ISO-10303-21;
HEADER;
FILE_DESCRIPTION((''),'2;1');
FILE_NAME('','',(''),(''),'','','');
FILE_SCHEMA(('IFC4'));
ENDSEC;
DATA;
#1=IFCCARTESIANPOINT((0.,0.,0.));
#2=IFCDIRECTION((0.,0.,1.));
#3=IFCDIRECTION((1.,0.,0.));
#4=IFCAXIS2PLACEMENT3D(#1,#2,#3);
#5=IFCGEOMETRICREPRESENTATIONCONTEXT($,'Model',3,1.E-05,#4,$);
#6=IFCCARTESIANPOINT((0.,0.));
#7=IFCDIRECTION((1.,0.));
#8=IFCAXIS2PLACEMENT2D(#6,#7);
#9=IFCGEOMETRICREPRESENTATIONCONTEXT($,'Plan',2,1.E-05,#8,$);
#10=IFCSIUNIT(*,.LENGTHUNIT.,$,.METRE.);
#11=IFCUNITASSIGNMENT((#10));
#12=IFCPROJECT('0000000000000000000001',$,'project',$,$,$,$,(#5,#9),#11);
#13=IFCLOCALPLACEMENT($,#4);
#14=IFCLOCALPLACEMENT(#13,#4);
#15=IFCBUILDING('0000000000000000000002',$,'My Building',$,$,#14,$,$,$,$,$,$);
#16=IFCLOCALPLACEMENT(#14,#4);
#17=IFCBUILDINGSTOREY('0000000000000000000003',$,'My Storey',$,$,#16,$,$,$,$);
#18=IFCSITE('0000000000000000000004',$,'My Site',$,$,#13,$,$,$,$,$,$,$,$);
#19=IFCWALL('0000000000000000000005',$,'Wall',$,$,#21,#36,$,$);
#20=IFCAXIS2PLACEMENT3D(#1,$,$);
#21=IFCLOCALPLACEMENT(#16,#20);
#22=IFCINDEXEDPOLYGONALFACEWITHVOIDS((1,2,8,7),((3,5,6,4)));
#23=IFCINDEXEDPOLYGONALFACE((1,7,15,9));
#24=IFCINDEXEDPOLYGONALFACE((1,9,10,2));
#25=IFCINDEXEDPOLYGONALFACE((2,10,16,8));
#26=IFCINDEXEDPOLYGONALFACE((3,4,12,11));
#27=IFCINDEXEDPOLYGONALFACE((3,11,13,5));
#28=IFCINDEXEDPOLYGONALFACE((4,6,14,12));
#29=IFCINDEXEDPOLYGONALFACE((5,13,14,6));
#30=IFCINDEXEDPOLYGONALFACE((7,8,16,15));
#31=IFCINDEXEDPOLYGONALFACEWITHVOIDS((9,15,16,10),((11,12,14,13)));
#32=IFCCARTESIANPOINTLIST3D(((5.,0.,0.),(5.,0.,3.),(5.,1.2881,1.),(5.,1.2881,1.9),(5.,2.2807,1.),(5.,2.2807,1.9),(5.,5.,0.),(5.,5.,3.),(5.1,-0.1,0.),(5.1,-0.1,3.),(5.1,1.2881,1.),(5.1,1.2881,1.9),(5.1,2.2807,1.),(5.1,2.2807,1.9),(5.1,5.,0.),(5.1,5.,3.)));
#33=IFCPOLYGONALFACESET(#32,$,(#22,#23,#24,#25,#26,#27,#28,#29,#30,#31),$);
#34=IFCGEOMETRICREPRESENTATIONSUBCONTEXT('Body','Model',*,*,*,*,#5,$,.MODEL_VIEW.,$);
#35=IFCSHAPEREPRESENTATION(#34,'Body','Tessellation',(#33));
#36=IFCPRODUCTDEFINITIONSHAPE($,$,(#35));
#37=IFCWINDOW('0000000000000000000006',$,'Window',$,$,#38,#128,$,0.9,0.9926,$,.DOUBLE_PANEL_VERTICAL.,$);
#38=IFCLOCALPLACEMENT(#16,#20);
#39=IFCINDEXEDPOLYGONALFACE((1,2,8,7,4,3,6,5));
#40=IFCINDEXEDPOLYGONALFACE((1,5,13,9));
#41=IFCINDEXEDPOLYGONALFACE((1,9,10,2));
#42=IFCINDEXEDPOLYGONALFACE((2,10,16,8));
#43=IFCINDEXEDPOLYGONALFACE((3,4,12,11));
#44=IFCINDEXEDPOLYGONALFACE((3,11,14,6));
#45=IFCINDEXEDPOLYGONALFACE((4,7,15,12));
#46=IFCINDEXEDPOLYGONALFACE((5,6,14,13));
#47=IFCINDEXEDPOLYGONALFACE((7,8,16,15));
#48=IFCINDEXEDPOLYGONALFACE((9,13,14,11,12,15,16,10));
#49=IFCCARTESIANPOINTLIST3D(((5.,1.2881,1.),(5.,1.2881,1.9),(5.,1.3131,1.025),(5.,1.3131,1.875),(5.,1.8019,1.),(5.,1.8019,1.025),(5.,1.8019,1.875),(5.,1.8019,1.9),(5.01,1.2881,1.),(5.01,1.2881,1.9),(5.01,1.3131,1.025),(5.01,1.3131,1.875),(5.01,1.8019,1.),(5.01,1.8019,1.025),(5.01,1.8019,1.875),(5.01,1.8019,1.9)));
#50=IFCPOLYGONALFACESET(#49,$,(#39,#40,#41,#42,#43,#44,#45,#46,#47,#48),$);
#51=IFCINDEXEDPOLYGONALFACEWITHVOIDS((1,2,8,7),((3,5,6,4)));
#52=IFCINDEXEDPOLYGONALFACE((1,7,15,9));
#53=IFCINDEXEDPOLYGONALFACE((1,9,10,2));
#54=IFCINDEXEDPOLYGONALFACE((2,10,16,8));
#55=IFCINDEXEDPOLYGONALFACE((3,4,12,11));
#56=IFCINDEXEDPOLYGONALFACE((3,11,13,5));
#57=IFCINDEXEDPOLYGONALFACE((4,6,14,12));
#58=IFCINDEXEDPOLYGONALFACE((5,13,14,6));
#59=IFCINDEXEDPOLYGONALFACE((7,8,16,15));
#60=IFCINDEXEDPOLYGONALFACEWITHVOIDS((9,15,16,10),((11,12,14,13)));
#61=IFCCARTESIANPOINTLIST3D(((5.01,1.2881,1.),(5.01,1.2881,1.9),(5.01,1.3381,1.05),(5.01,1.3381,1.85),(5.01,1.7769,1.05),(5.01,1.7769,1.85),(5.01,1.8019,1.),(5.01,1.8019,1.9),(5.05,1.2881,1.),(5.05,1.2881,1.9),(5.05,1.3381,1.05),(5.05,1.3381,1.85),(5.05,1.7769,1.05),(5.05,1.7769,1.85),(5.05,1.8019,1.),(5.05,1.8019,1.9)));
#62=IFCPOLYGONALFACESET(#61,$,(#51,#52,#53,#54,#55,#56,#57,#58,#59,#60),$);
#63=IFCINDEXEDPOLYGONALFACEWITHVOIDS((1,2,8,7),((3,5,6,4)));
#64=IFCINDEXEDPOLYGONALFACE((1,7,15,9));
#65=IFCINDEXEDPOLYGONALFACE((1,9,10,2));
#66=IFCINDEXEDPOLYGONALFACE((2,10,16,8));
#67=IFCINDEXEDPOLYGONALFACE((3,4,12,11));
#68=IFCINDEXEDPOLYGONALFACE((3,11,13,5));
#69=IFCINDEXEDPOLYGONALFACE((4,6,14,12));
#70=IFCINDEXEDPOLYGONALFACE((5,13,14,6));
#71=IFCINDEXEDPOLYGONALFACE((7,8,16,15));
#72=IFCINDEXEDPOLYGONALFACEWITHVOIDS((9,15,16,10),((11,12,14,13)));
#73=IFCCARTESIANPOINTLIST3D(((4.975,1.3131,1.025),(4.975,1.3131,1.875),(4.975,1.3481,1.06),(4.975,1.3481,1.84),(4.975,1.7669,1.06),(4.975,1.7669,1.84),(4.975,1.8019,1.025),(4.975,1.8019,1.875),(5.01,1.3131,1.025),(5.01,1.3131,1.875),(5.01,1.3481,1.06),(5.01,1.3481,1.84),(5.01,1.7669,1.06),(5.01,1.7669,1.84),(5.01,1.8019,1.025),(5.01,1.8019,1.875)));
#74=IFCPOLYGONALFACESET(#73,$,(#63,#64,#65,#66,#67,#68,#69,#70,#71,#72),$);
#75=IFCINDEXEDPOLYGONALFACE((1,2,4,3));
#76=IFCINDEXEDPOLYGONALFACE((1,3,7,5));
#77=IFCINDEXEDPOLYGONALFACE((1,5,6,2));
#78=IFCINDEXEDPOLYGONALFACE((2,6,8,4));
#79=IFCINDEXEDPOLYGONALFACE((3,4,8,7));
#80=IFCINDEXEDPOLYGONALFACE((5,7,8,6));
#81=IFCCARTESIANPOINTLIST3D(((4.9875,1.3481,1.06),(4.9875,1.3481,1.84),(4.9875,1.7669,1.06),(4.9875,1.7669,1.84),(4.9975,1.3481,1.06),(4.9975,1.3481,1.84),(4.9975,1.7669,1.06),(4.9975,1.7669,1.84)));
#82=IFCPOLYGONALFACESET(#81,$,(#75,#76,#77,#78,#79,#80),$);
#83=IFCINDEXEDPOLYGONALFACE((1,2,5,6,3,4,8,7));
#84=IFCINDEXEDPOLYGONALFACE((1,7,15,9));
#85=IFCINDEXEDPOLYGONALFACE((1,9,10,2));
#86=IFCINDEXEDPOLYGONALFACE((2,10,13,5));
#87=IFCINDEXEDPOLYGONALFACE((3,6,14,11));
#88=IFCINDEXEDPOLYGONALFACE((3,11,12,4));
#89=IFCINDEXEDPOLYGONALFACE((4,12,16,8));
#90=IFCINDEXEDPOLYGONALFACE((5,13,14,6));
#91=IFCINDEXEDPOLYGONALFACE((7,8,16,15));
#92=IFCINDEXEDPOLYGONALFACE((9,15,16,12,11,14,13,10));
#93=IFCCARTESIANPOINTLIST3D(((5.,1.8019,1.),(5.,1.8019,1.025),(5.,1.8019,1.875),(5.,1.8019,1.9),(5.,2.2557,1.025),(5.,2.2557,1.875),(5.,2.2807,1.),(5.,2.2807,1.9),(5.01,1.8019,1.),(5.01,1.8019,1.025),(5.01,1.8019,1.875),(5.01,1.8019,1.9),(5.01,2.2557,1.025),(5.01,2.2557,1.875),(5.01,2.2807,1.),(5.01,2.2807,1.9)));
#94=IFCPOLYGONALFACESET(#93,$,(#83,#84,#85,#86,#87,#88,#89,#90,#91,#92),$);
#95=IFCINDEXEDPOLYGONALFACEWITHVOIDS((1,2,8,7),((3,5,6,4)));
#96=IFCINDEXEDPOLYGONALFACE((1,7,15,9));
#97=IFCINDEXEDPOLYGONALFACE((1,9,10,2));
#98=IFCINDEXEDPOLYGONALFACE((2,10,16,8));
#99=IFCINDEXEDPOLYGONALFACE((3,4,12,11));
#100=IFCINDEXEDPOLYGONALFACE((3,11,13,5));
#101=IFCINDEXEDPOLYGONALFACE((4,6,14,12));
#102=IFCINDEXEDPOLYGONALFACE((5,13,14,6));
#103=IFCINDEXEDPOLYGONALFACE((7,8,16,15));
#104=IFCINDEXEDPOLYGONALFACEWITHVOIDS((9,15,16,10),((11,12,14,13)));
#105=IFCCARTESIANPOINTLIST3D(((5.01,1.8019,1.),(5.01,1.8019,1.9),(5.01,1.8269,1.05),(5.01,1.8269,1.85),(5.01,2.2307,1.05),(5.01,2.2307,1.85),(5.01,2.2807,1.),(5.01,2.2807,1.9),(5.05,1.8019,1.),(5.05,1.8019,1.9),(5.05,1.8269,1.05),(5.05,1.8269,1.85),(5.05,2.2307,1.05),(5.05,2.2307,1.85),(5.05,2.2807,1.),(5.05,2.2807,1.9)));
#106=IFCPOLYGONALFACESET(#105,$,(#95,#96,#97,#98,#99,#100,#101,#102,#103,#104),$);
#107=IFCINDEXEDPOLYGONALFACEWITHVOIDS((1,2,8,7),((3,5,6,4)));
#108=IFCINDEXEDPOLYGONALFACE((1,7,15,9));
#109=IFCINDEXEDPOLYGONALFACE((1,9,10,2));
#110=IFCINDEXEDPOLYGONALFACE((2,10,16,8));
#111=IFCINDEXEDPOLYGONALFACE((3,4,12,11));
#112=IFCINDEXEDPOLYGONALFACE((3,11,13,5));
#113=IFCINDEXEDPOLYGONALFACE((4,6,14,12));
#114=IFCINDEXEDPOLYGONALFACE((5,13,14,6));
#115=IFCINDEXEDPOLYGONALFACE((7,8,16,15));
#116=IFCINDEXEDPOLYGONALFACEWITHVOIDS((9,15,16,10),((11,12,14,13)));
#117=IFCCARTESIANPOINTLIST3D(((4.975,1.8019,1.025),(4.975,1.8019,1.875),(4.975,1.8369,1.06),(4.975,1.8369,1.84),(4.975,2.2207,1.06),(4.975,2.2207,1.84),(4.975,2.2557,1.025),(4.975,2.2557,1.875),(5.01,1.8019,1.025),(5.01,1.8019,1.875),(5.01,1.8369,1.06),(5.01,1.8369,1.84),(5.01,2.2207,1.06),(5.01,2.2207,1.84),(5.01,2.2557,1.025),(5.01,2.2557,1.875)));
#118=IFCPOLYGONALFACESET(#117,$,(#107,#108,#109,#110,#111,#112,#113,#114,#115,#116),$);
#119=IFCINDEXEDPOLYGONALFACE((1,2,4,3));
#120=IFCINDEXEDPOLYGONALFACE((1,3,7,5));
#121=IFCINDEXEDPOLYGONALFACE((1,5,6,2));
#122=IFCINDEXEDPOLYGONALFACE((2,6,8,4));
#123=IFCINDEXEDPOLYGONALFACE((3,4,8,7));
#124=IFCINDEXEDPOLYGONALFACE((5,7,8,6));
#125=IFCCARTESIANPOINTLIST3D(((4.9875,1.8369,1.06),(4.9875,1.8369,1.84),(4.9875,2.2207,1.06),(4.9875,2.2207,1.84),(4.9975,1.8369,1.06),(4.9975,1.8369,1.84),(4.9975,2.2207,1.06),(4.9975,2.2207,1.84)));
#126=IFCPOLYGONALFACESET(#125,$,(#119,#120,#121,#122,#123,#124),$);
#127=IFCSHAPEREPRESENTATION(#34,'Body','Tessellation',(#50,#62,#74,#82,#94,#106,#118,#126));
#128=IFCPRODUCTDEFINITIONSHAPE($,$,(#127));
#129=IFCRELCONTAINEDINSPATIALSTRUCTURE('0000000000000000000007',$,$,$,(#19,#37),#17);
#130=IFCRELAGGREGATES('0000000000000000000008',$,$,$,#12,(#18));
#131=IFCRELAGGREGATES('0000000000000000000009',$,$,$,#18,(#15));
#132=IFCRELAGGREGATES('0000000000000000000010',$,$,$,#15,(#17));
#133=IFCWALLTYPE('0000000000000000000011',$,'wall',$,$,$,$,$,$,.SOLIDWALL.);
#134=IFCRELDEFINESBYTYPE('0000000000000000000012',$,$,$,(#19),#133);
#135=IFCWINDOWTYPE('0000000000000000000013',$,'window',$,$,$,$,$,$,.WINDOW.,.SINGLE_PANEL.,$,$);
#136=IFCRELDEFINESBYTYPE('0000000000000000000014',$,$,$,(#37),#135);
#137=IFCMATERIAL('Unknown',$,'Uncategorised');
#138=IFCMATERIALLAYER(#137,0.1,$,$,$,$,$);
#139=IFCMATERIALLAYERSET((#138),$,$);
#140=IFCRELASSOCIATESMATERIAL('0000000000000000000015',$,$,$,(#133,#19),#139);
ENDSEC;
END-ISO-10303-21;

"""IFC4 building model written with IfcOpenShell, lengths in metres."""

from ifc_helpers import new_model, entity, si_unit, frame, origin_with_axes, origin_2d_with_axis, place, context, subcontext, project, spatial, line, indexed_curve, outline, extrude, shape, source, transform, mapped, material, layer, layer_set, layer_usage, type_object, type_shapes, element, fill, save


model = new_model("IFC4")

# Units and contexts
model_context = context("Model", 3, precision=1e-05, world=origin_with_axes())
plan_context = context("Plan", 2, precision=1e-05, world=origin_2d_with_axis())
body_context_1 = subcontext(model_context, "Body", "Model", "MODEL_VIEW")
body_context_2 = subcontext(plan_context, "Body", "Plan", "PLAN_VIEW")
ifc_project = project(units=[si_unit("LENGTHUNIT", "METRE")], contexts=[model_context, plan_context])

# Site, building, storey
site_placement = place(None, origin_with_axes())
site = spatial("IfcSite", under=ifc_project, at=site_placement, Name="My Site")
building_placement = place(site_placement, origin_with_axes())
building = spatial("IfcBuilding", under=site, at=building_placement, Name="My Building")
storey_placement = place(building_placement, origin_with_axes())
storey = spatial("IfcBuildingStorey", under=building, at=storey_placement, Name="My Storey")

# Shared definitions
ifc_material = material(Name="Unknown", Category="Uncategorised")

# Shared definitions
ifc_layer_1 = layer(ifc_material, 0.1)
ifc_layer_set_1 = layer_set([ifc_layer_1])
wall_type = type_object("IfcWallType", Name="wall", PredefinedType="SOLIDWALL", material=ifc_layer_set_1)
shared_shape_1 = source(origin_with_axes(), body_context_1, "Body", "SweptSolid", [
    extrude(outline(indexed_curve([(0.0, 0.0), (0.9926, 0.0), (0.9926, 0.9), (0.0, 0.9)], segments=[line(1, 2, 3, 4, 1)])), frame((0.0, -0.6, 0.0), z_axis=(0.0, -1.0, 0.0), x_axis=(1.0, 0.0, 0.0)), (0.0, 0.0, -1.0), 1.2),
])
window_type_1 = type_object("IfcWindowType", Name="window", PartitioningType="SINGLE_PANEL", PredefinedType="WINDOW")
shared_shape_2 = source(origin_with_axes(), body_context_1, "Body", "SweptSolid", [
    extrude(outline(indexed_curve([(0.5138, 0.0), (0.0, 0.0), (0.0, 0.9), (0.5138, 0.9), (0.5138, 0.875), (0.025, 0.875), (0.025, 0.025), (0.5138, 0.025)], segments=[line(1, 2, 3, 4, 5, 6, 7, 8, 1)])), frame((0.0, 0.09, 0.0), z_axis=(0.0, -1.0, 0.0), x_axis=(1.0, 0.0, 0.0)), (0.0, 0.0, -1.0), 0.01),
    extrude(outline(indexed_curve([(0.0, 0.0), (0.5138, 0.0), (0.5138, 0.9), (0.0, 0.9)], segments=[line(1, 2, 3, 4, 1)]), holes=[indexed_curve([(0.05, 0.05), (0.4888, 0.05), (0.4888, 0.85), (0.05, 0.85)], segments=[line(1, 2, 3, 4, 1)])]), frame((0.0, 0.05, 0.0), z_axis=(0.0, -1.0, 0.0), x_axis=(1.0, 0.0, 0.0)), (0.0, 0.0, -1.0), 0.04),
    extrude(outline(indexed_curve([(0.0, 0.0), (0.4888, 0.0), (0.4888, 0.85), (0.0, 0.85)], segments=[line(1, 2, 3, 4, 1)]), holes=[indexed_curve([(0.035, 0.035), (0.4538, 0.035), (0.4538, 0.815), (0.035, 0.815)], segments=[line(1, 2, 3, 4, 1)])]), frame((0.025, 0.09, 0.025), z_axis=(0.0, -1.0, 0.0), x_axis=(1.0, 0.0, 0.0)), (0.0, 0.0, -1.0), 0.035),
    extrude(outline(indexed_curve([(0.035, 0.035), (0.4538, 0.035), (0.4538, 0.815), (0.035, 0.815)], segments=[line(1, 2, 3, 4, 1)])), frame((0.025, 0.1025, 0.025), z_axis=(0.0, -1.0, 0.0), x_axis=(1.0, 0.0, 0.0)), (0.0, 0.0, -1.0), 0.01),
    extrude(outline(indexed_curve([(0.0, 0.9), (0.4788, 0.9), (0.4788, 0.0), (0.0, 0.0), (0.0, 0.025), (0.4538, 0.025), (0.4538, 0.875), (0.0, 0.875)], segments=[line(1, 2, 3, 4, 5, 6, 7, 8, 1)])), frame((0.5138, 0.09, 0.0), z_axis=(0.0, -1.0, 0.0), x_axis=(1.0, 0.0, 0.0)), (0.0, 0.0, -1.0), 0.01),
    extrude(outline(indexed_curve([(0.0, 0.0), (0.4788, 0.0), (0.4788, 0.9), (0.0, 0.9)], segments=[line(1, 2, 3, 4, 1)]), holes=[indexed_curve([(0.025, 0.05), (0.4288, 0.05), (0.4288, 0.85), (0.025, 0.85)], segments=[line(1, 2, 3, 4, 1)])]), frame((0.5138, 0.05, 0.0), z_axis=(0.0, -1.0, 0.0), x_axis=(1.0, 0.0, 0.0)), (0.0, 0.0, -1.0), 0.04),
    extrude(outline(indexed_curve([(0.0, 0.0), (0.4538, 0.0), (0.4538, 0.85), (0.0, 0.85)], segments=[line(1, 2, 3, 4, 1)]), holes=[indexed_curve([(0.035, 0.035), (0.4188, 0.035), (0.4188, 0.815), (0.035, 0.815)], segments=[line(1, 2, 3, 4, 1)])]), frame((0.5138, 0.09, 0.025), z_axis=(0.0, -1.0, 0.0), x_axis=(1.0, 0.0, 0.0)), (0.0, 0.0, -1.0), 0.035),
    extrude(outline(indexed_curve([(0.035, 0.035), (0.4188, 0.035), (0.4188, 0.815), (0.035, 0.815)], segments=[line(1, 2, 3, 4, 1)])), frame((0.5138, 0.1025, 0.025), z_axis=(0.0, -1.0, 0.0), x_axis=(1.0, 0.0, 0.0)), (0.0, 0.0, -1.0), 0.01),
])
shared_shape_3 = source(origin_with_axes(), body_context_2, "Body", "Curve2D", [
    entity("IfcIndexedPolyCurve", entity("IfcCartesianPointList2D", [[0.05, 0.05], [0.4888, 0.05]])),
    entity("IfcIndexedPolyCurve", entity("IfcCartesianPointList2D", [[0.0, 0.1], [0.025, 0.1], [0.025, 0.09], [0.05, 0.09], [0.05, 0.05], [0.0, 0.05]]), [entity("IfcLineIndex", [1, 2, 3, 4, 5, 6, 1])]),
    entity("IfcIndexedPolyCurve", entity("IfcCartesianPointList2D", [[0.5138, 0.1], [0.5138, 0.1], [0.5138, 0.09], [0.4888, 0.09], [0.4888, 0.05], [0.5138, 0.05]])),
    entity("IfcIndexedPolyCurve", entity("IfcCartesianPointList2D", [[0.025, 0.09], [0.06, 0.09], [0.06, 0.125], [0.025, 0.125]]), [entity("IfcLineIndex", [1, 2, 3, 4, 1])]),
    entity("IfcIndexedPolyCurve", entity("IfcCartesianPointList2D", [[0.5138, 0.09], [0.4788, 0.09], [0.4788, 0.125], [0.5138, 0.125]]), [entity("IfcLineIndex", [1, 2, 3, 4, 1])]),
    entity("IfcIndexedPolyCurve", entity("IfcCartesianPointList2D", [[0.06, 0.09], [0.4788, 0.09]])),
    entity("IfcIndexedPolyCurve", entity("IfcCartesianPointList2D", [[0.06, 0.125], [0.4788, 0.125]])),
    entity("IfcIndexedPolyCurve", entity("IfcCartesianPointList2D", [[0.06, 0.1075], [0.4788, 0.1075]])),
    entity("IfcIndexedPolyCurve", entity("IfcCartesianPointList2D", [[0.5388, 0.05], [0.9426, 0.05]])),
    entity("IfcIndexedPolyCurve", entity("IfcCartesianPointList2D", [[0.5138, 0.1], [0.5138, 0.1], [0.5138, 0.09], [0.5388, 0.09], [0.5388, 0.05], [0.5138, 0.05]])),
    entity("IfcIndexedPolyCurve", entity("IfcCartesianPointList2D", [[0.9926, 0.1], [0.9676, 0.1], [0.9676, 0.09], [0.9426, 0.09], [0.9426, 0.05], [0.9926, 0.05]]), [entity("IfcLineIndex", [1, 2, 3, 4, 5, 6, 1])]),
    entity("IfcIndexedPolyCurve", entity("IfcCartesianPointList2D", [[0.5138, 0.09], [0.5488, 0.09], [0.5488, 0.125], [0.5138, 0.125]]), [entity("IfcLineIndex", [1, 2, 3, 4, 1])]),
    entity("IfcIndexedPolyCurve", entity("IfcCartesianPointList2D", [[0.9676, 0.09], [0.9326, 0.09], [0.9326, 0.125], [0.9676, 0.125]]), [entity("IfcLineIndex", [1, 2, 3, 4, 1])]),
    entity("IfcIndexedPolyCurve", entity("IfcCartesianPointList2D", [[0.5488, 0.09], [0.9326, 0.09]])),
    entity("IfcIndexedPolyCurve", entity("IfcCartesianPointList2D", [[0.5488, 0.125], [0.9326, 0.125]])),
    entity("IfcIndexedPolyCurve", entity("IfcCartesianPointList2D", [[0.5488, 0.1075], [0.9326, 0.1075]])),
])
type_shapes(window_type_1, [shared_shape_2, shared_shape_3])

# Wall, opening, window
ifc_layer_usage_1 = layer_usage(ifc_layer_set_1, "AXIS2", "POSITIVE", 0.0)
wall_1_placement = place(storey_placement, frame((5.0, 5.0, 0.0), z_axis=(0.0, 0.0, 1.0), x_axis=(0.0, -1.0, 0.0)))
wall_1 = element("IfcWall", 1, at=wall_1_placement, inside=storey, type_object=wall_type, material=ifc_layer_usage_1, Name="Wall", context=body_context_1, shape_type="SweptSolid", body=[
    extrude(outline(indexed_curve([(0.0, 0.0), (0.0, 0.1), (5.1, 0.1), (5.0, 0.0)], segments=[line(1, 2, 3, 4, 1)])), origin_with_axes(), (0.0, 0.0, 1.0), 3.0),
])
opening_1_placement = place(wall_1_placement, frame((3.7119, 0.1, 1.0), z_axis=(0.0, 0.0, 1.0), x_axis=(-1.0, 0.0, 0.0)))
opening_1 = element("IfcOpeningElement", 2, at=opening_1_placement, cuts=wall_1, PredefinedType="OPENING", context=body_context_1, shape_type="MappedRepresentation", body=[
    mapped(shared_shape_1, transform((0.0, 0.0, 0.0), x_axis=(1.0, 0.0, 0.0), y_axis=(0.0, 1.0, 0.0), z_axis=(0.0, 0.0, 1.0), scale=1.0)),
])
window_1_placement = place(opening_1_placement, frame((0.0, 0.0, 0.0), z_axis=(0.0, 0.0, 1.0), x_axis=(1.0, 0.0, 0.0)))
window_1 = element("IfcWindow", 3, at=window_1_placement, inside=storey, type_object=window_type_1, Name="Window", OverallHeight=0.9, OverallWidth=0.9926, PartitioningType="DOUBLE_PANEL_VERTICAL", shapes=[
    shape(body_context_1, "Body", "MappedRepresentation", [mapped(shared_shape_2, transform((0.0, 0.0, 0.0), x_axis=(1.0, 0.0, 0.0), y_axis=(0.0, 1.0, 0.0), z_axis=(0.0, 0.0, 1.0), scale=1.0))]),
    shape(body_context_2, "Body", "MappedRepresentation", [mapped(shared_shape_3, transform((0.0, 0.0, 0.0), x_axis=(1.0, 0.0, 0.0), y_axis=(0.0, 1.0, 0.0), z_axis=(0.0, 0.0, 1.0), scale=1.0))]),
])
fill(opening_1, window_1)

save(model, "model.ifc")
